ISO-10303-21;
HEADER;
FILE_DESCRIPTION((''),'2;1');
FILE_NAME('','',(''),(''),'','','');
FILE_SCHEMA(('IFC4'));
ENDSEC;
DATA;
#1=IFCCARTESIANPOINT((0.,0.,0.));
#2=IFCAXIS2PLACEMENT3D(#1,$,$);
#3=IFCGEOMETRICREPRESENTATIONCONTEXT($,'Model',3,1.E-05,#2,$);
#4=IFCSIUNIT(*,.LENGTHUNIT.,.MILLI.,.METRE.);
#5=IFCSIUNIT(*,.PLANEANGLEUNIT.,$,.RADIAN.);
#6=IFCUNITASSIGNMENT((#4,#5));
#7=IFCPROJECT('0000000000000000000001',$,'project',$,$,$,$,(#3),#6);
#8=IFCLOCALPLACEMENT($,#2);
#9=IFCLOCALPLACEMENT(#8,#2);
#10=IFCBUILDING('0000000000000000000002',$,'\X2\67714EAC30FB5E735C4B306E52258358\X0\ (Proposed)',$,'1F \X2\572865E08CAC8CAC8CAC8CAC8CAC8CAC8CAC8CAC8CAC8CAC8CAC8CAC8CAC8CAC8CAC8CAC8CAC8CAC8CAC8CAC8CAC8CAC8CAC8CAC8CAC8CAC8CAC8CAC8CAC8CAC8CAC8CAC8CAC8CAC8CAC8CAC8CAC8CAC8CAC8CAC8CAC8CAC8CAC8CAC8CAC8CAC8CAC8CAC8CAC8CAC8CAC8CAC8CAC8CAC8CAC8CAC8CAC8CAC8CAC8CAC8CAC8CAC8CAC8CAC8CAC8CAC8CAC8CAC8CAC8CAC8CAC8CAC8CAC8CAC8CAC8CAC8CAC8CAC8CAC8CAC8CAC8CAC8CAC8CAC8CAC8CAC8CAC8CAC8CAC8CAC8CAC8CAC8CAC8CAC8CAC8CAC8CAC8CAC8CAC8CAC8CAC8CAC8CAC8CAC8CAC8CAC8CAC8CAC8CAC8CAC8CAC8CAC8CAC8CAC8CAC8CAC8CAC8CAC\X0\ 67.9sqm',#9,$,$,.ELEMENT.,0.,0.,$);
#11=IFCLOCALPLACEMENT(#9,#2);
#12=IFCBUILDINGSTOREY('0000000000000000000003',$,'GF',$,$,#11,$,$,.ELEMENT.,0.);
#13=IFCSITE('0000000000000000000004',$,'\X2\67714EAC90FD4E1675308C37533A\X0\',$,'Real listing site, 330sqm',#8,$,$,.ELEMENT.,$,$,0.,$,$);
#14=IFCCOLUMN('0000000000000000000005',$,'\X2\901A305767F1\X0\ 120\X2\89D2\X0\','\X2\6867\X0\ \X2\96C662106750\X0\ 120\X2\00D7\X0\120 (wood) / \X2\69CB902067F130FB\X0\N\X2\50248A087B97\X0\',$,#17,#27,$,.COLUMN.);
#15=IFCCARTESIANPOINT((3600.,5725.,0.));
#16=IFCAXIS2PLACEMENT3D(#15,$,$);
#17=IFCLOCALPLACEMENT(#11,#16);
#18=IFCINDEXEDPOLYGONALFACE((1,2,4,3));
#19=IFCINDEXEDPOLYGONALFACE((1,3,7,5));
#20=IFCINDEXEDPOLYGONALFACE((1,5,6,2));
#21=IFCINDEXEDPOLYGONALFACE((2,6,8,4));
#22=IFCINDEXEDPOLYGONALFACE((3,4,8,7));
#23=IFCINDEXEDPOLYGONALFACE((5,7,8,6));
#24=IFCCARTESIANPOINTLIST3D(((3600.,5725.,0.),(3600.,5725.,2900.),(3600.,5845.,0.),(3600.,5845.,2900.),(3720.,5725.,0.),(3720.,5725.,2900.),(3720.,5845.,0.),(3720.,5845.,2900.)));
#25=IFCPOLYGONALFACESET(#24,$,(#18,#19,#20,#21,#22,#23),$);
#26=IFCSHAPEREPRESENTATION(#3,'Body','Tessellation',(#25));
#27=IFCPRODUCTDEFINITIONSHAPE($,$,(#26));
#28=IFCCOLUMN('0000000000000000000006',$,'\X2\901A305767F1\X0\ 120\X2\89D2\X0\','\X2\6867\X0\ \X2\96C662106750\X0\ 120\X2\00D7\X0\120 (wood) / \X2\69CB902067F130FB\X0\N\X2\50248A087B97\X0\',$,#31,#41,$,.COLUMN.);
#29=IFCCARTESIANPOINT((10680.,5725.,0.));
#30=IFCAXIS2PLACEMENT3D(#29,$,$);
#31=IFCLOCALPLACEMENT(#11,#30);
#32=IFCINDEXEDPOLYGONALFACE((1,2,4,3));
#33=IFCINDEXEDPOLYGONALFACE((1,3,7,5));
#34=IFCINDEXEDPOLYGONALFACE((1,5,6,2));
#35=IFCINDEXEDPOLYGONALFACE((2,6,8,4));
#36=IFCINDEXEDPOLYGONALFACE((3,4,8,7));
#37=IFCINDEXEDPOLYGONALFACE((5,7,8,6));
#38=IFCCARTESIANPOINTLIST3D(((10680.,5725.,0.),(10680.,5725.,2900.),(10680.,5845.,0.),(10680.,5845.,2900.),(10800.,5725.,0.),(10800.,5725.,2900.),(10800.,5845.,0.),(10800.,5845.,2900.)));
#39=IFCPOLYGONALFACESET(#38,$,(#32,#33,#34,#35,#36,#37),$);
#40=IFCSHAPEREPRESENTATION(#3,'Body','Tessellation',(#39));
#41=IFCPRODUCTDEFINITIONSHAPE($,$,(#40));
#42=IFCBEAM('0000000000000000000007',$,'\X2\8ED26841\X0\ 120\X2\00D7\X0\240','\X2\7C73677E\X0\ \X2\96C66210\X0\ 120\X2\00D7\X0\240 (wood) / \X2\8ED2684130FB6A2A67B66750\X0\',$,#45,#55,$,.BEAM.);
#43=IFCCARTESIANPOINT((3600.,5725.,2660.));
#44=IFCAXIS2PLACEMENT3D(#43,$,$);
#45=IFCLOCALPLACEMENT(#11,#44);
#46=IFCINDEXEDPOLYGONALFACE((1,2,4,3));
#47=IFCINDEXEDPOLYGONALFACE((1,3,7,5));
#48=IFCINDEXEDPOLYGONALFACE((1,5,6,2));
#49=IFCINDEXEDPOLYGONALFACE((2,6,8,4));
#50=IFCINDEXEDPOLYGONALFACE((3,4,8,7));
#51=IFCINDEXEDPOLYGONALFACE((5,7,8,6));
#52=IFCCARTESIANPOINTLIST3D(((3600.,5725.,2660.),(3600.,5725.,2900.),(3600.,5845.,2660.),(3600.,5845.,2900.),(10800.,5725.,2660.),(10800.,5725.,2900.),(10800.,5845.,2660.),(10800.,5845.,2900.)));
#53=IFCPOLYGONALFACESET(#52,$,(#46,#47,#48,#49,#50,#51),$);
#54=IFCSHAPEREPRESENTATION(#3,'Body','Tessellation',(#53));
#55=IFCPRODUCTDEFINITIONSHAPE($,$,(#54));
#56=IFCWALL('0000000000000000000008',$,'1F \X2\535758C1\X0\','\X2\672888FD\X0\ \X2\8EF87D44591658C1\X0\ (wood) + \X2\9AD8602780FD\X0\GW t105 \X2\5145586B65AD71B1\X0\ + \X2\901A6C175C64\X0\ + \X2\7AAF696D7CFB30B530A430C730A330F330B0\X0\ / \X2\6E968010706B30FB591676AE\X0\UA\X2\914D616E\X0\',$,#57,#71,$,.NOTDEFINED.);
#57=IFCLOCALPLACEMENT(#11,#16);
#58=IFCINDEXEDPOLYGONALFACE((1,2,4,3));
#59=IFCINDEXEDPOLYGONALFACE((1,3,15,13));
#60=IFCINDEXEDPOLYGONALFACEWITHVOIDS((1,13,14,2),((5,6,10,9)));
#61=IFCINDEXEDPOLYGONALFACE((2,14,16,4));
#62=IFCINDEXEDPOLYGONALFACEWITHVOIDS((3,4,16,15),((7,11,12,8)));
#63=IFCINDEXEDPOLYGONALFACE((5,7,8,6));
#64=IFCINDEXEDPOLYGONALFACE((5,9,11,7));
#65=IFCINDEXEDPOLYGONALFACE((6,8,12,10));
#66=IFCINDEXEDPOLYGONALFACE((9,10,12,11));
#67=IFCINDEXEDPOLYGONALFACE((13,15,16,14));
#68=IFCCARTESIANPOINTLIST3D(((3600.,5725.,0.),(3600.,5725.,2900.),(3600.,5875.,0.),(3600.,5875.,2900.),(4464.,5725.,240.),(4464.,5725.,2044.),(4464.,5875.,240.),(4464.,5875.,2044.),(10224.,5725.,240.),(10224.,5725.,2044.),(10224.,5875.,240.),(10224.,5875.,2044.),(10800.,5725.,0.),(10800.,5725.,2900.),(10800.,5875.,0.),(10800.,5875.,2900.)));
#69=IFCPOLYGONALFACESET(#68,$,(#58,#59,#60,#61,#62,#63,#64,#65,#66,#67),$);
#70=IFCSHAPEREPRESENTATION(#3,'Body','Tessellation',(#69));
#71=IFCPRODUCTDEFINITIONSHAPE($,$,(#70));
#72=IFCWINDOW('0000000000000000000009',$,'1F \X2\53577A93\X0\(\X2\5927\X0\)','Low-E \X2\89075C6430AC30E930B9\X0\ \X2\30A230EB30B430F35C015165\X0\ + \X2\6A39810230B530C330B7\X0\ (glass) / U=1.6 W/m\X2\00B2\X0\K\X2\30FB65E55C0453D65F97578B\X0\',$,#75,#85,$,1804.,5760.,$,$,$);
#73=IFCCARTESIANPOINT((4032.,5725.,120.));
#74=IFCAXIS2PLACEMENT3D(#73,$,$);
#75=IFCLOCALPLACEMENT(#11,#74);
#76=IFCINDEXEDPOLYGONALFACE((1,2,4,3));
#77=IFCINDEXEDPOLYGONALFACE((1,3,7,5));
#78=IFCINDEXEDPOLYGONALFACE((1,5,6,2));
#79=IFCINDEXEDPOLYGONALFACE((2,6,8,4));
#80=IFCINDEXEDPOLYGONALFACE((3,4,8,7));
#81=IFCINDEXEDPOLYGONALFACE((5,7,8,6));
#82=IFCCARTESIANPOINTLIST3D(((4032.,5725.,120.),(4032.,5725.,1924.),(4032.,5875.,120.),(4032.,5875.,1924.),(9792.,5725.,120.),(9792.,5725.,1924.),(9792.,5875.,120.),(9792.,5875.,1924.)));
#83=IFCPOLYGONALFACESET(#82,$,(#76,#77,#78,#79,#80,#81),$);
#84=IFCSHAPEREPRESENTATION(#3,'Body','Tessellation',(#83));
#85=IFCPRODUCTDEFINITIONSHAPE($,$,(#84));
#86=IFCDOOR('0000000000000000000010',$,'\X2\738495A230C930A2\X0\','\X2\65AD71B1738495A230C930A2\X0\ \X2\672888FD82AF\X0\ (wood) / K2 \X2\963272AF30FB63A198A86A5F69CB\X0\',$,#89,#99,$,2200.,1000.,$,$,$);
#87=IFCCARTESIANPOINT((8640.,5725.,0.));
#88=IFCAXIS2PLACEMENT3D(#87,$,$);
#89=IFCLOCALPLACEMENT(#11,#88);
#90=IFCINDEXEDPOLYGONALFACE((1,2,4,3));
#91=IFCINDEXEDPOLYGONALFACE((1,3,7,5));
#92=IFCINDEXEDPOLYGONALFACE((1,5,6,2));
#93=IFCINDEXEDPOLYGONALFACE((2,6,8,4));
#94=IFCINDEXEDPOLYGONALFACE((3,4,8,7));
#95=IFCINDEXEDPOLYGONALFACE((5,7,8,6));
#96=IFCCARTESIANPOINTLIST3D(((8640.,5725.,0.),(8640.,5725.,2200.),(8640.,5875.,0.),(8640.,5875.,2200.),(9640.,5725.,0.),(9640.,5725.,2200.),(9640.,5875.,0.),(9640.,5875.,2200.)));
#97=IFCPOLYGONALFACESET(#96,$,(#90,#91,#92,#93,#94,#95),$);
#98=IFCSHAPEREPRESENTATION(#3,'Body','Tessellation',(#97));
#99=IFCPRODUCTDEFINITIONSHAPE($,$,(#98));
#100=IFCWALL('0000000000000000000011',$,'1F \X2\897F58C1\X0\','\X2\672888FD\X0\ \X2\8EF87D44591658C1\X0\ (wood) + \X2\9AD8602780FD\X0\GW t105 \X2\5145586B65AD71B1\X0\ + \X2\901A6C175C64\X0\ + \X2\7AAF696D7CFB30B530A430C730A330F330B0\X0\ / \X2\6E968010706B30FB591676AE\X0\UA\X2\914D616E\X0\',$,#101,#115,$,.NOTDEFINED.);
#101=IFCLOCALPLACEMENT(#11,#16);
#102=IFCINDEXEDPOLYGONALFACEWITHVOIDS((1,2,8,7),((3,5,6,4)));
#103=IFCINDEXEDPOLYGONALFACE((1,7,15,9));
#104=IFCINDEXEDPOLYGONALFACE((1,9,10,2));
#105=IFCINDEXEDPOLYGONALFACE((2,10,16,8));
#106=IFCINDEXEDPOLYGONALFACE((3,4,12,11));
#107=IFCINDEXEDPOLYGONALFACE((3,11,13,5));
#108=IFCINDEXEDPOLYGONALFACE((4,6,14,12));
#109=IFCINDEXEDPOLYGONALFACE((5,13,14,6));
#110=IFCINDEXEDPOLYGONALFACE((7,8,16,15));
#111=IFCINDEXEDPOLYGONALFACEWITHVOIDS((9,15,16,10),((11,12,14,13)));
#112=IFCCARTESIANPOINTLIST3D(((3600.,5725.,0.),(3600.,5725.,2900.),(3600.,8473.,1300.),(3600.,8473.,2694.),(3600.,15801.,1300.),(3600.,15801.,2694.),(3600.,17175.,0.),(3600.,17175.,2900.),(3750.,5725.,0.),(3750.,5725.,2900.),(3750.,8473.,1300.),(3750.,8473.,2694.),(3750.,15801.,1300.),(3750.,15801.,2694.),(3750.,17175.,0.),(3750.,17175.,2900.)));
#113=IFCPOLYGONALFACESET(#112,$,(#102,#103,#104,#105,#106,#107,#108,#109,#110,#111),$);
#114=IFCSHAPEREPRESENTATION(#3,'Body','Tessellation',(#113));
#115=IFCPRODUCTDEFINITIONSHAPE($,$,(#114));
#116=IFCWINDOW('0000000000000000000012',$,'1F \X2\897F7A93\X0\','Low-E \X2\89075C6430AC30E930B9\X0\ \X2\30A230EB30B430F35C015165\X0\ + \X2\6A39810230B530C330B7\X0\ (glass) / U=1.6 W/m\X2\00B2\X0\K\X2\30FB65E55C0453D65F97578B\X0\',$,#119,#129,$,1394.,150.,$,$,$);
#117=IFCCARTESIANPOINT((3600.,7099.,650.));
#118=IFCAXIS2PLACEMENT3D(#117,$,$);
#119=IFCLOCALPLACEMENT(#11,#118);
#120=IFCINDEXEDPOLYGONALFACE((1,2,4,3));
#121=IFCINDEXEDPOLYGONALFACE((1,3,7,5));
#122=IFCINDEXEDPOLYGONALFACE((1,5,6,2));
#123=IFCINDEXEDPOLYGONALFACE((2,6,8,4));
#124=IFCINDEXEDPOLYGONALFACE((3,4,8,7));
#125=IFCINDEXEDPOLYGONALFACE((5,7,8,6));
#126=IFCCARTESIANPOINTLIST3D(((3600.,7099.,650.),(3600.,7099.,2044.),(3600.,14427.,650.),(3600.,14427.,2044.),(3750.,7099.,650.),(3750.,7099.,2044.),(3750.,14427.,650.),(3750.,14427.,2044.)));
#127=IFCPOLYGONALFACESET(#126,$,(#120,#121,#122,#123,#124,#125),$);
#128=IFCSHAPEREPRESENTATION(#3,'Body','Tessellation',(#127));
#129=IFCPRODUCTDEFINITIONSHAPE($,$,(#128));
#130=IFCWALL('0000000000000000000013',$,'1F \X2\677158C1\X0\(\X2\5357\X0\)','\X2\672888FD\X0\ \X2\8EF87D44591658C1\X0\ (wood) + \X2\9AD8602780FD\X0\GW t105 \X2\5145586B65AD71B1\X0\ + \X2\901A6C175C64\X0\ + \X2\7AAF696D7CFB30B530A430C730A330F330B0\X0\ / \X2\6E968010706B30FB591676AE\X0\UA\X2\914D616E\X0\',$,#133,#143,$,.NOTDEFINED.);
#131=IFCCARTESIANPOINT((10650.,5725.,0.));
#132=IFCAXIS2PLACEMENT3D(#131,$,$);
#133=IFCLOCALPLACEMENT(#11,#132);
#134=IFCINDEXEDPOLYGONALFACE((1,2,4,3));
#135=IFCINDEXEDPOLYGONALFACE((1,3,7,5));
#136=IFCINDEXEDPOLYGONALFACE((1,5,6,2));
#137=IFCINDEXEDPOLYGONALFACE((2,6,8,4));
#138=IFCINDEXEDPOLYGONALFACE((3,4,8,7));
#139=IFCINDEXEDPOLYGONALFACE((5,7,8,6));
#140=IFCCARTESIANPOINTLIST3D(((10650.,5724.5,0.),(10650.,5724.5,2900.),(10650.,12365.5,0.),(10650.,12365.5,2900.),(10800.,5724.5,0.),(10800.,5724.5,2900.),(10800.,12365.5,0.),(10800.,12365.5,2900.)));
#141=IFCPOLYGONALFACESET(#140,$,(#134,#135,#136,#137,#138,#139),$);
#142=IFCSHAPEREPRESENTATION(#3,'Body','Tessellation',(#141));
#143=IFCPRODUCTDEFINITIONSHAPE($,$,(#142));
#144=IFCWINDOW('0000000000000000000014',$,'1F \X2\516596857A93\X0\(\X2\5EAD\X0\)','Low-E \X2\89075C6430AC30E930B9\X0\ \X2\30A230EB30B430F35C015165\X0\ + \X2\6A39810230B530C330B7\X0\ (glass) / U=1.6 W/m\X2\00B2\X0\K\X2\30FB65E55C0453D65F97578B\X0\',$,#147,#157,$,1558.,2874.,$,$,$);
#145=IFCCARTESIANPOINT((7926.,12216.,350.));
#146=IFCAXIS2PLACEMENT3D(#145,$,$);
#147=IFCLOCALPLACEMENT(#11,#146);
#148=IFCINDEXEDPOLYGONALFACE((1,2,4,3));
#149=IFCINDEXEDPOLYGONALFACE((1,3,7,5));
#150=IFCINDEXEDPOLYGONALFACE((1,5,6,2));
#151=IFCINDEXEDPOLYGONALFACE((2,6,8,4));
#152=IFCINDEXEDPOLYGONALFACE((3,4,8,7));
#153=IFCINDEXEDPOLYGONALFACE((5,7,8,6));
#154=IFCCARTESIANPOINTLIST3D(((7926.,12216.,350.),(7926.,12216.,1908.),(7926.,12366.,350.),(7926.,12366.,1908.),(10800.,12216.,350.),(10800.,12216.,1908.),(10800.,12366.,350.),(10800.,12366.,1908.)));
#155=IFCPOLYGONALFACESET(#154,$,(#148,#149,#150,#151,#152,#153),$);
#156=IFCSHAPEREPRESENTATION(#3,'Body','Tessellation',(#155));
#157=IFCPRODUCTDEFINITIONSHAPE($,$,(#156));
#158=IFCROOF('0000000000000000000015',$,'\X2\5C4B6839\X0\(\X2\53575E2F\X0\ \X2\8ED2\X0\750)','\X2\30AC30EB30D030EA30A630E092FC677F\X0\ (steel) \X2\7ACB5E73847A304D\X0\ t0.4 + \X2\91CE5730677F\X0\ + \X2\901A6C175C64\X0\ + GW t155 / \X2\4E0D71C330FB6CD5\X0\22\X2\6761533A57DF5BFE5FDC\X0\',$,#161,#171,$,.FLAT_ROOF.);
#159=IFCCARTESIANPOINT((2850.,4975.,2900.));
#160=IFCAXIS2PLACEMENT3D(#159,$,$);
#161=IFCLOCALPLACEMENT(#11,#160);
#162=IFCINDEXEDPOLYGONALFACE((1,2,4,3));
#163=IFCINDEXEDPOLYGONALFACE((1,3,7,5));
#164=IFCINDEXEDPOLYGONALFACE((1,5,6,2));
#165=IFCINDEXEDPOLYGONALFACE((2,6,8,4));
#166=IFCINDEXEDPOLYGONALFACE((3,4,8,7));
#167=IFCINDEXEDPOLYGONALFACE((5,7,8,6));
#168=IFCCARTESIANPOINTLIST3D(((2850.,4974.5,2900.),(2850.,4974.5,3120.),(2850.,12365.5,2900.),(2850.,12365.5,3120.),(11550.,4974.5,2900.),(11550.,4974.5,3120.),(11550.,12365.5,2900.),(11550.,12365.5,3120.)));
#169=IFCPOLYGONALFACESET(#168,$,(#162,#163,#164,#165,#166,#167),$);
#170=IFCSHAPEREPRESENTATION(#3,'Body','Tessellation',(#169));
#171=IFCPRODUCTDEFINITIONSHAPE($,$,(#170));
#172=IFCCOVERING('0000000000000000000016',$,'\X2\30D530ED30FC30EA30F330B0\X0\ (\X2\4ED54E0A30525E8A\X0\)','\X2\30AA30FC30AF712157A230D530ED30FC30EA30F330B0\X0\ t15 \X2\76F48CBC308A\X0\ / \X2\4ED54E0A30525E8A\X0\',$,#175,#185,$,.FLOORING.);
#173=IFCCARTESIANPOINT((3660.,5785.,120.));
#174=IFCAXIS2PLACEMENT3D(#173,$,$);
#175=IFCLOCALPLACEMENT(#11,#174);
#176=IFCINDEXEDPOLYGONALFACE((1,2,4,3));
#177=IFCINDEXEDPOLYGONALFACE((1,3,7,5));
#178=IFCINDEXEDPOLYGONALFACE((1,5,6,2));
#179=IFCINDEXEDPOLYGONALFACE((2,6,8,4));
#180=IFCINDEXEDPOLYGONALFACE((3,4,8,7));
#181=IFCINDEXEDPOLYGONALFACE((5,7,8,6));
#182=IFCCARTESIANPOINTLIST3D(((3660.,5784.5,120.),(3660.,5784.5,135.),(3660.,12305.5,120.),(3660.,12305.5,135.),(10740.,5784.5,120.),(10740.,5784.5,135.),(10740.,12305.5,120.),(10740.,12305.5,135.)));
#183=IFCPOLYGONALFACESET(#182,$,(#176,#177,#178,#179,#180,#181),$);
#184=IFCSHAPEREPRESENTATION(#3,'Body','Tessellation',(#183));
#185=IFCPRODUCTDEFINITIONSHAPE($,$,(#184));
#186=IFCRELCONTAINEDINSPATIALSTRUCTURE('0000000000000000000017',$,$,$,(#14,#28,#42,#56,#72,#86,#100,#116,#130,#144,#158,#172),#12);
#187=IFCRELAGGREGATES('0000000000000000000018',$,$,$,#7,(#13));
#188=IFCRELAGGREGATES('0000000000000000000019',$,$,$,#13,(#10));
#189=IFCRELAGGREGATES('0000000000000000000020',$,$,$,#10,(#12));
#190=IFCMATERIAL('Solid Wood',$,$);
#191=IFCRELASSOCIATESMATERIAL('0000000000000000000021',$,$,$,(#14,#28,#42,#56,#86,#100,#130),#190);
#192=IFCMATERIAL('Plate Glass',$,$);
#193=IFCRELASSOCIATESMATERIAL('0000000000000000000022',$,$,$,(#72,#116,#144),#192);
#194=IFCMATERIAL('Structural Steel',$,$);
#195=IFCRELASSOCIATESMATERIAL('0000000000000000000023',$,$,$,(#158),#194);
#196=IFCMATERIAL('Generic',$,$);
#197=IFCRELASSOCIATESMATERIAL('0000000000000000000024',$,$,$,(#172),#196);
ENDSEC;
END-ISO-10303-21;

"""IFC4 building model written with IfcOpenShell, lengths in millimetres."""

from ifc_helpers import new_model, si_unit, frame, frame_2d, origin, place, context, project, spatial, rectangle, extrude, material, element, fill, save


model = new_model("IFC4")

# Units and contexts
model_context = context("Model", 3, precision=1e-05, world=origin())
ifc_project = project(units=[si_unit("LENGTHUNIT", "METRE", prefix="MILLI"), si_unit("PLANEANGLEUNIT", "RADIAN")], contexts=[model_context])

# Site, building, storey
site_placement = place(None, origin())
site = spatial("IfcSite", under=ifc_project, at=site_placement, Name="東京都世田谷区", ObjectType="Real listing site, 330sqm", CompositionType="ELEMENT", RefElevation=0.0)
building_placement = place(site_placement, origin())
building = spatial("IfcBuilding", under=site, at=building_placement, Name="東京・平屋の別荘 (Proposed)", ObjectType="1F 在无責責責責責責責責責責責責責責責責責責責責責責責責責責責責責責責責責責責責責責責責責責責責責責責責責責責責責責責責責責責責責責責責責責責責責責責責責責責責責責責責責責責責責責責責責責責責責責責責責責責責責責責責責責責責責責責責責責責責責責 67.9sqm", CompositionType="ELEMENT", ElevationOfRefHeight=0.0, ElevationOfTerrain=0.0)
storey_placement = place(building_placement, origin())
storey = spatial("IfcBuildingStorey", under=building, at=storey_placement, Name="GF", CompositionType="ELEMENT", Elevation=0.0)

# Columns
ifc_material_1 = material(Name="Solid Wood")
column_1_placement = place(storey_placement, frame((3600.0, 5725.0, 0.0)))
element("IfcColumn", 1, at=column_1_placement, inside=storey, material=ifc_material_1, Name="通し柱 120角", Description="桧 集成材 120×120 (wood) / 構造柱・N値計算", PredefinedType="COLUMN", context=model_context, shape_type="SweptSolid", body=[
    extrude(rectangle(XDim=120.0, YDim=120.0, at=frame_2d((60.0, 60.0))), frame((3600.0, 5725.0, 0.0)), (0.0, 0.0, 1.0), 2900.0),
])
column_2_placement = place(storey_placement, frame((10680.0, 5725.0, 0.0)))
element("IfcColumn", 2, at=column_2_placement, inside=storey, material=ifc_material_1, Name="通し柱 120角", Description="桧 集成材 120×120 (wood) / 構造柱・N値計算", PredefinedType="COLUMN", context=model_context, shape_type="SweptSolid", body=[
    extrude(rectangle(XDim=120.0, YDim=120.0, at=frame_2d((60.0, 60.0))), frame((10680.0, 5725.0, 0.0)), (0.0, 0.0, 1.0), 2900.0),
])

# Beam
beam_1_placement = place(storey_placement, frame((3600.0, 5725.0, 2660.0)))
element("IfcBeam", 3, at=beam_1_placement, inside=storey, material=ifc_material_1, Name="軒桁 120×240", Description="米松 集成 120×240 (wood) / 軒桁・横架材", PredefinedType="BEAM", context=model_context, shape_type="SweptSolid", body=[
    extrude(rectangle(XDim=7200.0, YDim=120.0, at=frame_2d((3600.0, 60.0))), frame((3600.0, 5725.0, 2660.0)), (0.0, 0.0, 1.0), 240.0),
])

# Wall, openings, window, door
wall_1_placement = place(storey_placement, frame((3600.0, 5725.0, 0.0)))
wall_1 = element("IfcWall", 4, at=wall_1_placement, inside=storey, material=ifc_material_1, Name="1F 南壁", Description="木製 軸組外壁 (wood) + 高性能GW t105 充填断熱 + 通気層 + 窯業系サイディング / 準耐火・外皮UA配慮", PredefinedType="NOTDEFINED", context=model_context, shape_type="SweptSolid", body=[
    extrude(rectangle(XDim=7200.0, YDim=150.0, at=frame_2d((3600.0, 75.0))), frame((3600.0, 5725.0, 0.0)), (0.0, 0.0, 1.0), 2900.0),
])
opening_1_placement = place(storey_placement, frame((4032.0, 5725.0, 120.0)))
opening_1 = element("IfcOpeningElement", 5, at=opening_1_placement, cuts=wall_1, PredefinedType="NOTDEFINED", context=model_context, shape_type="SweptSolid", body=[
    extrude(rectangle(XDim=5760.0, YDim=150.0, at=frame_2d((2880.0, 75.0))), frame((4032.0, 5725.0, 120.0)), (0.0, 0.0, 1.0), 1804.0),
])
opening_2_placement = place(storey_placement, frame((8640.0, 5725.0, 0.0)))
opening_2 = element("IfcOpeningElement", 6, at=opening_2_placement, cuts=wall_1, PredefinedType="NOTDEFINED", context=model_context, shape_type="SweptSolid", body=[
    extrude(rectangle(XDim=1000.0, YDim=150.0, at=frame_2d((500.0, 75.0))), frame((8640.0, 5725.0, 0.0)), (0.0, 0.0, 1.0), 2200.0),
])
ifc_material_2 = material(Name="Plate Glass")
window_1_placement = place(storey_placement, frame((4032.0, 5725.0, 120.0)))
window_1 = element("IfcWindow", 7, at=window_1_placement, inside=storey, material=ifc_material_2, Name="1F 南窓(大)", Description="Low-E 複層ガラス アルゴン封入 + 樹脂サッシ (glass) / U=1.6 W/m²K・日射取得型", OverallHeight=1804.0, OverallWidth=5760.0, context=model_context, shape_type="SweptSolid", body=[
    extrude(rectangle(XDim=5760.0, YDim=150.0, at=frame_2d((2880.0, 75.0))), frame((4032.0, 5725.0, 120.0)), (0.0, 0.0, 1.0), 1804.0),
])
fill(opening_1, window_1)
door_1_placement = place(storey_placement, frame((8640.0, 5725.0, 0.0)))
door_1 = element("IfcDoor", 8, at=door_1_placement, inside=storey, material=ifc_material_1, Name="玄関ドア", Description="断熱玄関ドア 木製芯 (wood) / K2 防犯・採風機構", OverallHeight=2200.0, OverallWidth=1000.0, context=model_context, shape_type="SweptSolid", body=[
    extrude(rectangle(XDim=1000.0, YDim=150.0, at=frame_2d((500.0, 75.0))), frame((8640.0, 5725.0, 0.0)), (0.0, 0.0, 1.0), 2200.0),
])
fill(opening_2, door_1)

# Walls, openings, windows
wall_2_placement = place(storey_placement, frame((3600.0, 5725.0, 0.0)))
wall_2 = element("IfcWall", 9, at=wall_2_placement, inside=storey, material=ifc_material_1, Name="1F 西壁", Description="木製 軸組外壁 (wood) + 高性能GW t105 充填断熱 + 通気層 + 窯業系サイディング / 準耐火・外皮UA配慮", PredefinedType="NOTDEFINED", context=model_context, shape_type="SweptSolid", body=[
    extrude(rectangle(XDim=150.0, YDim=11450.0, at=frame_2d((75.0, 5725.0))), frame((3600.0, 5725.0, 0.0)), (0.0, 0.0, 1.0), 2900.0),
])
opening_3_placement = place(storey_placement, frame((3600.0, 7099.0, 650.0)))
opening_3 = element("IfcOpeningElement", 10, at=opening_3_placement, cuts=wall_2, PredefinedType="NOTDEFINED", context=model_context, shape_type="SweptSolid", body=[
    extrude(rectangle(XDim=150.0, YDim=7328.0, at=frame_2d((75.0, 3664.0))), frame((3600.0, 7099.0, 650.0)), (0.0, 0.0, 1.0), 1394.0),
])
window_2_placement = place(storey_placement, frame((3600.0, 7099.0, 650.0)))
window_2 = element("IfcWindow", 11, at=window_2_placement, inside=storey, material=ifc_material_2, Name="1F 西窓", Description="Low-E 複層ガラス アルゴン封入 + 樹脂サッシ (glass) / U=1.6 W/m²K・日射取得型", OverallHeight=1394.0, OverallWidth=150.0, context=model_context, shape_type="SweptSolid", body=[
    extrude(rectangle(XDim=150.0, YDim=7328.0, at=frame_2d((75.0, 3664.0))), frame((3600.0, 7099.0, 650.0)), (0.0, 0.0, 1.0), 1394.0),
])
fill(opening_3, window_2)
wall_3_placement = place(storey_placement, frame((10650.0, 5725.0, 0.0)))
wall_3 = element("IfcWall", 12, at=wall_3_placement, inside=storey, material=ifc_material_1, Name="1F 東壁(南)", Description="木製 軸組外壁 (wood) + 高性能GW t105 充填断熱 + 通気層 + 窯業系サイディング / 準耐火・外皮UA配慮", PredefinedType="NOTDEFINED", context=model_context, shape_type="SweptSolid", body=[
    extrude(rectangle(XDim=150.0, YDim=6641.0, at=frame_2d((75.0, 3320.0))), frame((10650.0, 5725.0, 0.0)), (0.0, 0.0, 1.0), 2900.0),
])
opening_4_placement = place(storey_placement, frame((7926.0, 12216.0, 350.0)))
opening_4 = element("IfcOpeningElement", 13, at=opening_4_placement, cuts=wall_3, PredefinedType="NOTDEFINED", context=model_context, shape_type="SweptSolid", body=[
    extrude(rectangle(XDim=2874.0, YDim=150.0, at=frame_2d((1437.0, 75.0))), frame((7926.0, 12216.0, 350.0)), (0.0, 0.0, 1.0), 1558.0),
])
window_3_placement = place(storey_placement, frame((7926.0, 12216.0, 350.0)))
window_3 = element("IfcWindow", 14, at=window_3_placement, inside=storey, material=ifc_material_2, Name="1F 入隅窓(庭)", Description="Low-E 複層ガラス アルゴン封入 + 樹脂サッシ (glass) / U=1.6 W/m²K・日射取得型", OverallHeight=1558.0, OverallWidth=2874.0, context=model_context, shape_type="SweptSolid", body=[
    extrude(rectangle(XDim=2874.0, YDim=150.0, at=frame_2d((1437.0, 75.0))), frame((7926.0, 12216.0, 350.0)), (0.0, 0.0, 1.0), 1558.0),
])
fill(opening_4, window_3)

# Roof
ifc_material_3 = material(Name="Structural Steel")
roof_placement = place(storey_placement, frame((2850.0, 4975.0, 2900.0)))
element("IfcRoof", 15, at=roof_placement, inside=storey, material=ifc_material_3, Name="屋根(南帯 軒750)", Description="ガルバリウム鋼板 (steel) 立平葺き t0.4 + 野地板 + 通気層 + GW t155 / 不燃・法22条区域対応", PredefinedType="FLAT_ROOF", context=model_context, shape_type="SweptSolid", body=[
    extrude(rectangle(XDim=8700.0, YDim=7391.0, at=frame_2d((4350.0, 3695.0))), frame((2850.0, 4975.0, 2900.0)), (0.0, 0.0, 1.0), 220.0),
])

# Covering
ifc_material_4 = material(Name="Generic")
covering_1_placement = place(storey_placement, frame((3660.0, 5785.0, 120.0)))
element("IfcCovering", 16, at=covering_1_placement, inside=storey, material=ifc_material_4, Name="フローリング (仕上げ床)", Description="オーク無垢フローリング t15 直貼り / 仕上げ床", PredefinedType="FLOORING", context=model_context, shape_type="SweptSolid", body=[
    extrude(rectangle(XDim=7080.0, YDim=6521.0, at=frame_2d((3540.0, 3260.0))), frame((3660.0, 5785.0, 120.0)), (0.0, 0.0, 1.0), 15.0),
])

save(model, "model.ifc")
